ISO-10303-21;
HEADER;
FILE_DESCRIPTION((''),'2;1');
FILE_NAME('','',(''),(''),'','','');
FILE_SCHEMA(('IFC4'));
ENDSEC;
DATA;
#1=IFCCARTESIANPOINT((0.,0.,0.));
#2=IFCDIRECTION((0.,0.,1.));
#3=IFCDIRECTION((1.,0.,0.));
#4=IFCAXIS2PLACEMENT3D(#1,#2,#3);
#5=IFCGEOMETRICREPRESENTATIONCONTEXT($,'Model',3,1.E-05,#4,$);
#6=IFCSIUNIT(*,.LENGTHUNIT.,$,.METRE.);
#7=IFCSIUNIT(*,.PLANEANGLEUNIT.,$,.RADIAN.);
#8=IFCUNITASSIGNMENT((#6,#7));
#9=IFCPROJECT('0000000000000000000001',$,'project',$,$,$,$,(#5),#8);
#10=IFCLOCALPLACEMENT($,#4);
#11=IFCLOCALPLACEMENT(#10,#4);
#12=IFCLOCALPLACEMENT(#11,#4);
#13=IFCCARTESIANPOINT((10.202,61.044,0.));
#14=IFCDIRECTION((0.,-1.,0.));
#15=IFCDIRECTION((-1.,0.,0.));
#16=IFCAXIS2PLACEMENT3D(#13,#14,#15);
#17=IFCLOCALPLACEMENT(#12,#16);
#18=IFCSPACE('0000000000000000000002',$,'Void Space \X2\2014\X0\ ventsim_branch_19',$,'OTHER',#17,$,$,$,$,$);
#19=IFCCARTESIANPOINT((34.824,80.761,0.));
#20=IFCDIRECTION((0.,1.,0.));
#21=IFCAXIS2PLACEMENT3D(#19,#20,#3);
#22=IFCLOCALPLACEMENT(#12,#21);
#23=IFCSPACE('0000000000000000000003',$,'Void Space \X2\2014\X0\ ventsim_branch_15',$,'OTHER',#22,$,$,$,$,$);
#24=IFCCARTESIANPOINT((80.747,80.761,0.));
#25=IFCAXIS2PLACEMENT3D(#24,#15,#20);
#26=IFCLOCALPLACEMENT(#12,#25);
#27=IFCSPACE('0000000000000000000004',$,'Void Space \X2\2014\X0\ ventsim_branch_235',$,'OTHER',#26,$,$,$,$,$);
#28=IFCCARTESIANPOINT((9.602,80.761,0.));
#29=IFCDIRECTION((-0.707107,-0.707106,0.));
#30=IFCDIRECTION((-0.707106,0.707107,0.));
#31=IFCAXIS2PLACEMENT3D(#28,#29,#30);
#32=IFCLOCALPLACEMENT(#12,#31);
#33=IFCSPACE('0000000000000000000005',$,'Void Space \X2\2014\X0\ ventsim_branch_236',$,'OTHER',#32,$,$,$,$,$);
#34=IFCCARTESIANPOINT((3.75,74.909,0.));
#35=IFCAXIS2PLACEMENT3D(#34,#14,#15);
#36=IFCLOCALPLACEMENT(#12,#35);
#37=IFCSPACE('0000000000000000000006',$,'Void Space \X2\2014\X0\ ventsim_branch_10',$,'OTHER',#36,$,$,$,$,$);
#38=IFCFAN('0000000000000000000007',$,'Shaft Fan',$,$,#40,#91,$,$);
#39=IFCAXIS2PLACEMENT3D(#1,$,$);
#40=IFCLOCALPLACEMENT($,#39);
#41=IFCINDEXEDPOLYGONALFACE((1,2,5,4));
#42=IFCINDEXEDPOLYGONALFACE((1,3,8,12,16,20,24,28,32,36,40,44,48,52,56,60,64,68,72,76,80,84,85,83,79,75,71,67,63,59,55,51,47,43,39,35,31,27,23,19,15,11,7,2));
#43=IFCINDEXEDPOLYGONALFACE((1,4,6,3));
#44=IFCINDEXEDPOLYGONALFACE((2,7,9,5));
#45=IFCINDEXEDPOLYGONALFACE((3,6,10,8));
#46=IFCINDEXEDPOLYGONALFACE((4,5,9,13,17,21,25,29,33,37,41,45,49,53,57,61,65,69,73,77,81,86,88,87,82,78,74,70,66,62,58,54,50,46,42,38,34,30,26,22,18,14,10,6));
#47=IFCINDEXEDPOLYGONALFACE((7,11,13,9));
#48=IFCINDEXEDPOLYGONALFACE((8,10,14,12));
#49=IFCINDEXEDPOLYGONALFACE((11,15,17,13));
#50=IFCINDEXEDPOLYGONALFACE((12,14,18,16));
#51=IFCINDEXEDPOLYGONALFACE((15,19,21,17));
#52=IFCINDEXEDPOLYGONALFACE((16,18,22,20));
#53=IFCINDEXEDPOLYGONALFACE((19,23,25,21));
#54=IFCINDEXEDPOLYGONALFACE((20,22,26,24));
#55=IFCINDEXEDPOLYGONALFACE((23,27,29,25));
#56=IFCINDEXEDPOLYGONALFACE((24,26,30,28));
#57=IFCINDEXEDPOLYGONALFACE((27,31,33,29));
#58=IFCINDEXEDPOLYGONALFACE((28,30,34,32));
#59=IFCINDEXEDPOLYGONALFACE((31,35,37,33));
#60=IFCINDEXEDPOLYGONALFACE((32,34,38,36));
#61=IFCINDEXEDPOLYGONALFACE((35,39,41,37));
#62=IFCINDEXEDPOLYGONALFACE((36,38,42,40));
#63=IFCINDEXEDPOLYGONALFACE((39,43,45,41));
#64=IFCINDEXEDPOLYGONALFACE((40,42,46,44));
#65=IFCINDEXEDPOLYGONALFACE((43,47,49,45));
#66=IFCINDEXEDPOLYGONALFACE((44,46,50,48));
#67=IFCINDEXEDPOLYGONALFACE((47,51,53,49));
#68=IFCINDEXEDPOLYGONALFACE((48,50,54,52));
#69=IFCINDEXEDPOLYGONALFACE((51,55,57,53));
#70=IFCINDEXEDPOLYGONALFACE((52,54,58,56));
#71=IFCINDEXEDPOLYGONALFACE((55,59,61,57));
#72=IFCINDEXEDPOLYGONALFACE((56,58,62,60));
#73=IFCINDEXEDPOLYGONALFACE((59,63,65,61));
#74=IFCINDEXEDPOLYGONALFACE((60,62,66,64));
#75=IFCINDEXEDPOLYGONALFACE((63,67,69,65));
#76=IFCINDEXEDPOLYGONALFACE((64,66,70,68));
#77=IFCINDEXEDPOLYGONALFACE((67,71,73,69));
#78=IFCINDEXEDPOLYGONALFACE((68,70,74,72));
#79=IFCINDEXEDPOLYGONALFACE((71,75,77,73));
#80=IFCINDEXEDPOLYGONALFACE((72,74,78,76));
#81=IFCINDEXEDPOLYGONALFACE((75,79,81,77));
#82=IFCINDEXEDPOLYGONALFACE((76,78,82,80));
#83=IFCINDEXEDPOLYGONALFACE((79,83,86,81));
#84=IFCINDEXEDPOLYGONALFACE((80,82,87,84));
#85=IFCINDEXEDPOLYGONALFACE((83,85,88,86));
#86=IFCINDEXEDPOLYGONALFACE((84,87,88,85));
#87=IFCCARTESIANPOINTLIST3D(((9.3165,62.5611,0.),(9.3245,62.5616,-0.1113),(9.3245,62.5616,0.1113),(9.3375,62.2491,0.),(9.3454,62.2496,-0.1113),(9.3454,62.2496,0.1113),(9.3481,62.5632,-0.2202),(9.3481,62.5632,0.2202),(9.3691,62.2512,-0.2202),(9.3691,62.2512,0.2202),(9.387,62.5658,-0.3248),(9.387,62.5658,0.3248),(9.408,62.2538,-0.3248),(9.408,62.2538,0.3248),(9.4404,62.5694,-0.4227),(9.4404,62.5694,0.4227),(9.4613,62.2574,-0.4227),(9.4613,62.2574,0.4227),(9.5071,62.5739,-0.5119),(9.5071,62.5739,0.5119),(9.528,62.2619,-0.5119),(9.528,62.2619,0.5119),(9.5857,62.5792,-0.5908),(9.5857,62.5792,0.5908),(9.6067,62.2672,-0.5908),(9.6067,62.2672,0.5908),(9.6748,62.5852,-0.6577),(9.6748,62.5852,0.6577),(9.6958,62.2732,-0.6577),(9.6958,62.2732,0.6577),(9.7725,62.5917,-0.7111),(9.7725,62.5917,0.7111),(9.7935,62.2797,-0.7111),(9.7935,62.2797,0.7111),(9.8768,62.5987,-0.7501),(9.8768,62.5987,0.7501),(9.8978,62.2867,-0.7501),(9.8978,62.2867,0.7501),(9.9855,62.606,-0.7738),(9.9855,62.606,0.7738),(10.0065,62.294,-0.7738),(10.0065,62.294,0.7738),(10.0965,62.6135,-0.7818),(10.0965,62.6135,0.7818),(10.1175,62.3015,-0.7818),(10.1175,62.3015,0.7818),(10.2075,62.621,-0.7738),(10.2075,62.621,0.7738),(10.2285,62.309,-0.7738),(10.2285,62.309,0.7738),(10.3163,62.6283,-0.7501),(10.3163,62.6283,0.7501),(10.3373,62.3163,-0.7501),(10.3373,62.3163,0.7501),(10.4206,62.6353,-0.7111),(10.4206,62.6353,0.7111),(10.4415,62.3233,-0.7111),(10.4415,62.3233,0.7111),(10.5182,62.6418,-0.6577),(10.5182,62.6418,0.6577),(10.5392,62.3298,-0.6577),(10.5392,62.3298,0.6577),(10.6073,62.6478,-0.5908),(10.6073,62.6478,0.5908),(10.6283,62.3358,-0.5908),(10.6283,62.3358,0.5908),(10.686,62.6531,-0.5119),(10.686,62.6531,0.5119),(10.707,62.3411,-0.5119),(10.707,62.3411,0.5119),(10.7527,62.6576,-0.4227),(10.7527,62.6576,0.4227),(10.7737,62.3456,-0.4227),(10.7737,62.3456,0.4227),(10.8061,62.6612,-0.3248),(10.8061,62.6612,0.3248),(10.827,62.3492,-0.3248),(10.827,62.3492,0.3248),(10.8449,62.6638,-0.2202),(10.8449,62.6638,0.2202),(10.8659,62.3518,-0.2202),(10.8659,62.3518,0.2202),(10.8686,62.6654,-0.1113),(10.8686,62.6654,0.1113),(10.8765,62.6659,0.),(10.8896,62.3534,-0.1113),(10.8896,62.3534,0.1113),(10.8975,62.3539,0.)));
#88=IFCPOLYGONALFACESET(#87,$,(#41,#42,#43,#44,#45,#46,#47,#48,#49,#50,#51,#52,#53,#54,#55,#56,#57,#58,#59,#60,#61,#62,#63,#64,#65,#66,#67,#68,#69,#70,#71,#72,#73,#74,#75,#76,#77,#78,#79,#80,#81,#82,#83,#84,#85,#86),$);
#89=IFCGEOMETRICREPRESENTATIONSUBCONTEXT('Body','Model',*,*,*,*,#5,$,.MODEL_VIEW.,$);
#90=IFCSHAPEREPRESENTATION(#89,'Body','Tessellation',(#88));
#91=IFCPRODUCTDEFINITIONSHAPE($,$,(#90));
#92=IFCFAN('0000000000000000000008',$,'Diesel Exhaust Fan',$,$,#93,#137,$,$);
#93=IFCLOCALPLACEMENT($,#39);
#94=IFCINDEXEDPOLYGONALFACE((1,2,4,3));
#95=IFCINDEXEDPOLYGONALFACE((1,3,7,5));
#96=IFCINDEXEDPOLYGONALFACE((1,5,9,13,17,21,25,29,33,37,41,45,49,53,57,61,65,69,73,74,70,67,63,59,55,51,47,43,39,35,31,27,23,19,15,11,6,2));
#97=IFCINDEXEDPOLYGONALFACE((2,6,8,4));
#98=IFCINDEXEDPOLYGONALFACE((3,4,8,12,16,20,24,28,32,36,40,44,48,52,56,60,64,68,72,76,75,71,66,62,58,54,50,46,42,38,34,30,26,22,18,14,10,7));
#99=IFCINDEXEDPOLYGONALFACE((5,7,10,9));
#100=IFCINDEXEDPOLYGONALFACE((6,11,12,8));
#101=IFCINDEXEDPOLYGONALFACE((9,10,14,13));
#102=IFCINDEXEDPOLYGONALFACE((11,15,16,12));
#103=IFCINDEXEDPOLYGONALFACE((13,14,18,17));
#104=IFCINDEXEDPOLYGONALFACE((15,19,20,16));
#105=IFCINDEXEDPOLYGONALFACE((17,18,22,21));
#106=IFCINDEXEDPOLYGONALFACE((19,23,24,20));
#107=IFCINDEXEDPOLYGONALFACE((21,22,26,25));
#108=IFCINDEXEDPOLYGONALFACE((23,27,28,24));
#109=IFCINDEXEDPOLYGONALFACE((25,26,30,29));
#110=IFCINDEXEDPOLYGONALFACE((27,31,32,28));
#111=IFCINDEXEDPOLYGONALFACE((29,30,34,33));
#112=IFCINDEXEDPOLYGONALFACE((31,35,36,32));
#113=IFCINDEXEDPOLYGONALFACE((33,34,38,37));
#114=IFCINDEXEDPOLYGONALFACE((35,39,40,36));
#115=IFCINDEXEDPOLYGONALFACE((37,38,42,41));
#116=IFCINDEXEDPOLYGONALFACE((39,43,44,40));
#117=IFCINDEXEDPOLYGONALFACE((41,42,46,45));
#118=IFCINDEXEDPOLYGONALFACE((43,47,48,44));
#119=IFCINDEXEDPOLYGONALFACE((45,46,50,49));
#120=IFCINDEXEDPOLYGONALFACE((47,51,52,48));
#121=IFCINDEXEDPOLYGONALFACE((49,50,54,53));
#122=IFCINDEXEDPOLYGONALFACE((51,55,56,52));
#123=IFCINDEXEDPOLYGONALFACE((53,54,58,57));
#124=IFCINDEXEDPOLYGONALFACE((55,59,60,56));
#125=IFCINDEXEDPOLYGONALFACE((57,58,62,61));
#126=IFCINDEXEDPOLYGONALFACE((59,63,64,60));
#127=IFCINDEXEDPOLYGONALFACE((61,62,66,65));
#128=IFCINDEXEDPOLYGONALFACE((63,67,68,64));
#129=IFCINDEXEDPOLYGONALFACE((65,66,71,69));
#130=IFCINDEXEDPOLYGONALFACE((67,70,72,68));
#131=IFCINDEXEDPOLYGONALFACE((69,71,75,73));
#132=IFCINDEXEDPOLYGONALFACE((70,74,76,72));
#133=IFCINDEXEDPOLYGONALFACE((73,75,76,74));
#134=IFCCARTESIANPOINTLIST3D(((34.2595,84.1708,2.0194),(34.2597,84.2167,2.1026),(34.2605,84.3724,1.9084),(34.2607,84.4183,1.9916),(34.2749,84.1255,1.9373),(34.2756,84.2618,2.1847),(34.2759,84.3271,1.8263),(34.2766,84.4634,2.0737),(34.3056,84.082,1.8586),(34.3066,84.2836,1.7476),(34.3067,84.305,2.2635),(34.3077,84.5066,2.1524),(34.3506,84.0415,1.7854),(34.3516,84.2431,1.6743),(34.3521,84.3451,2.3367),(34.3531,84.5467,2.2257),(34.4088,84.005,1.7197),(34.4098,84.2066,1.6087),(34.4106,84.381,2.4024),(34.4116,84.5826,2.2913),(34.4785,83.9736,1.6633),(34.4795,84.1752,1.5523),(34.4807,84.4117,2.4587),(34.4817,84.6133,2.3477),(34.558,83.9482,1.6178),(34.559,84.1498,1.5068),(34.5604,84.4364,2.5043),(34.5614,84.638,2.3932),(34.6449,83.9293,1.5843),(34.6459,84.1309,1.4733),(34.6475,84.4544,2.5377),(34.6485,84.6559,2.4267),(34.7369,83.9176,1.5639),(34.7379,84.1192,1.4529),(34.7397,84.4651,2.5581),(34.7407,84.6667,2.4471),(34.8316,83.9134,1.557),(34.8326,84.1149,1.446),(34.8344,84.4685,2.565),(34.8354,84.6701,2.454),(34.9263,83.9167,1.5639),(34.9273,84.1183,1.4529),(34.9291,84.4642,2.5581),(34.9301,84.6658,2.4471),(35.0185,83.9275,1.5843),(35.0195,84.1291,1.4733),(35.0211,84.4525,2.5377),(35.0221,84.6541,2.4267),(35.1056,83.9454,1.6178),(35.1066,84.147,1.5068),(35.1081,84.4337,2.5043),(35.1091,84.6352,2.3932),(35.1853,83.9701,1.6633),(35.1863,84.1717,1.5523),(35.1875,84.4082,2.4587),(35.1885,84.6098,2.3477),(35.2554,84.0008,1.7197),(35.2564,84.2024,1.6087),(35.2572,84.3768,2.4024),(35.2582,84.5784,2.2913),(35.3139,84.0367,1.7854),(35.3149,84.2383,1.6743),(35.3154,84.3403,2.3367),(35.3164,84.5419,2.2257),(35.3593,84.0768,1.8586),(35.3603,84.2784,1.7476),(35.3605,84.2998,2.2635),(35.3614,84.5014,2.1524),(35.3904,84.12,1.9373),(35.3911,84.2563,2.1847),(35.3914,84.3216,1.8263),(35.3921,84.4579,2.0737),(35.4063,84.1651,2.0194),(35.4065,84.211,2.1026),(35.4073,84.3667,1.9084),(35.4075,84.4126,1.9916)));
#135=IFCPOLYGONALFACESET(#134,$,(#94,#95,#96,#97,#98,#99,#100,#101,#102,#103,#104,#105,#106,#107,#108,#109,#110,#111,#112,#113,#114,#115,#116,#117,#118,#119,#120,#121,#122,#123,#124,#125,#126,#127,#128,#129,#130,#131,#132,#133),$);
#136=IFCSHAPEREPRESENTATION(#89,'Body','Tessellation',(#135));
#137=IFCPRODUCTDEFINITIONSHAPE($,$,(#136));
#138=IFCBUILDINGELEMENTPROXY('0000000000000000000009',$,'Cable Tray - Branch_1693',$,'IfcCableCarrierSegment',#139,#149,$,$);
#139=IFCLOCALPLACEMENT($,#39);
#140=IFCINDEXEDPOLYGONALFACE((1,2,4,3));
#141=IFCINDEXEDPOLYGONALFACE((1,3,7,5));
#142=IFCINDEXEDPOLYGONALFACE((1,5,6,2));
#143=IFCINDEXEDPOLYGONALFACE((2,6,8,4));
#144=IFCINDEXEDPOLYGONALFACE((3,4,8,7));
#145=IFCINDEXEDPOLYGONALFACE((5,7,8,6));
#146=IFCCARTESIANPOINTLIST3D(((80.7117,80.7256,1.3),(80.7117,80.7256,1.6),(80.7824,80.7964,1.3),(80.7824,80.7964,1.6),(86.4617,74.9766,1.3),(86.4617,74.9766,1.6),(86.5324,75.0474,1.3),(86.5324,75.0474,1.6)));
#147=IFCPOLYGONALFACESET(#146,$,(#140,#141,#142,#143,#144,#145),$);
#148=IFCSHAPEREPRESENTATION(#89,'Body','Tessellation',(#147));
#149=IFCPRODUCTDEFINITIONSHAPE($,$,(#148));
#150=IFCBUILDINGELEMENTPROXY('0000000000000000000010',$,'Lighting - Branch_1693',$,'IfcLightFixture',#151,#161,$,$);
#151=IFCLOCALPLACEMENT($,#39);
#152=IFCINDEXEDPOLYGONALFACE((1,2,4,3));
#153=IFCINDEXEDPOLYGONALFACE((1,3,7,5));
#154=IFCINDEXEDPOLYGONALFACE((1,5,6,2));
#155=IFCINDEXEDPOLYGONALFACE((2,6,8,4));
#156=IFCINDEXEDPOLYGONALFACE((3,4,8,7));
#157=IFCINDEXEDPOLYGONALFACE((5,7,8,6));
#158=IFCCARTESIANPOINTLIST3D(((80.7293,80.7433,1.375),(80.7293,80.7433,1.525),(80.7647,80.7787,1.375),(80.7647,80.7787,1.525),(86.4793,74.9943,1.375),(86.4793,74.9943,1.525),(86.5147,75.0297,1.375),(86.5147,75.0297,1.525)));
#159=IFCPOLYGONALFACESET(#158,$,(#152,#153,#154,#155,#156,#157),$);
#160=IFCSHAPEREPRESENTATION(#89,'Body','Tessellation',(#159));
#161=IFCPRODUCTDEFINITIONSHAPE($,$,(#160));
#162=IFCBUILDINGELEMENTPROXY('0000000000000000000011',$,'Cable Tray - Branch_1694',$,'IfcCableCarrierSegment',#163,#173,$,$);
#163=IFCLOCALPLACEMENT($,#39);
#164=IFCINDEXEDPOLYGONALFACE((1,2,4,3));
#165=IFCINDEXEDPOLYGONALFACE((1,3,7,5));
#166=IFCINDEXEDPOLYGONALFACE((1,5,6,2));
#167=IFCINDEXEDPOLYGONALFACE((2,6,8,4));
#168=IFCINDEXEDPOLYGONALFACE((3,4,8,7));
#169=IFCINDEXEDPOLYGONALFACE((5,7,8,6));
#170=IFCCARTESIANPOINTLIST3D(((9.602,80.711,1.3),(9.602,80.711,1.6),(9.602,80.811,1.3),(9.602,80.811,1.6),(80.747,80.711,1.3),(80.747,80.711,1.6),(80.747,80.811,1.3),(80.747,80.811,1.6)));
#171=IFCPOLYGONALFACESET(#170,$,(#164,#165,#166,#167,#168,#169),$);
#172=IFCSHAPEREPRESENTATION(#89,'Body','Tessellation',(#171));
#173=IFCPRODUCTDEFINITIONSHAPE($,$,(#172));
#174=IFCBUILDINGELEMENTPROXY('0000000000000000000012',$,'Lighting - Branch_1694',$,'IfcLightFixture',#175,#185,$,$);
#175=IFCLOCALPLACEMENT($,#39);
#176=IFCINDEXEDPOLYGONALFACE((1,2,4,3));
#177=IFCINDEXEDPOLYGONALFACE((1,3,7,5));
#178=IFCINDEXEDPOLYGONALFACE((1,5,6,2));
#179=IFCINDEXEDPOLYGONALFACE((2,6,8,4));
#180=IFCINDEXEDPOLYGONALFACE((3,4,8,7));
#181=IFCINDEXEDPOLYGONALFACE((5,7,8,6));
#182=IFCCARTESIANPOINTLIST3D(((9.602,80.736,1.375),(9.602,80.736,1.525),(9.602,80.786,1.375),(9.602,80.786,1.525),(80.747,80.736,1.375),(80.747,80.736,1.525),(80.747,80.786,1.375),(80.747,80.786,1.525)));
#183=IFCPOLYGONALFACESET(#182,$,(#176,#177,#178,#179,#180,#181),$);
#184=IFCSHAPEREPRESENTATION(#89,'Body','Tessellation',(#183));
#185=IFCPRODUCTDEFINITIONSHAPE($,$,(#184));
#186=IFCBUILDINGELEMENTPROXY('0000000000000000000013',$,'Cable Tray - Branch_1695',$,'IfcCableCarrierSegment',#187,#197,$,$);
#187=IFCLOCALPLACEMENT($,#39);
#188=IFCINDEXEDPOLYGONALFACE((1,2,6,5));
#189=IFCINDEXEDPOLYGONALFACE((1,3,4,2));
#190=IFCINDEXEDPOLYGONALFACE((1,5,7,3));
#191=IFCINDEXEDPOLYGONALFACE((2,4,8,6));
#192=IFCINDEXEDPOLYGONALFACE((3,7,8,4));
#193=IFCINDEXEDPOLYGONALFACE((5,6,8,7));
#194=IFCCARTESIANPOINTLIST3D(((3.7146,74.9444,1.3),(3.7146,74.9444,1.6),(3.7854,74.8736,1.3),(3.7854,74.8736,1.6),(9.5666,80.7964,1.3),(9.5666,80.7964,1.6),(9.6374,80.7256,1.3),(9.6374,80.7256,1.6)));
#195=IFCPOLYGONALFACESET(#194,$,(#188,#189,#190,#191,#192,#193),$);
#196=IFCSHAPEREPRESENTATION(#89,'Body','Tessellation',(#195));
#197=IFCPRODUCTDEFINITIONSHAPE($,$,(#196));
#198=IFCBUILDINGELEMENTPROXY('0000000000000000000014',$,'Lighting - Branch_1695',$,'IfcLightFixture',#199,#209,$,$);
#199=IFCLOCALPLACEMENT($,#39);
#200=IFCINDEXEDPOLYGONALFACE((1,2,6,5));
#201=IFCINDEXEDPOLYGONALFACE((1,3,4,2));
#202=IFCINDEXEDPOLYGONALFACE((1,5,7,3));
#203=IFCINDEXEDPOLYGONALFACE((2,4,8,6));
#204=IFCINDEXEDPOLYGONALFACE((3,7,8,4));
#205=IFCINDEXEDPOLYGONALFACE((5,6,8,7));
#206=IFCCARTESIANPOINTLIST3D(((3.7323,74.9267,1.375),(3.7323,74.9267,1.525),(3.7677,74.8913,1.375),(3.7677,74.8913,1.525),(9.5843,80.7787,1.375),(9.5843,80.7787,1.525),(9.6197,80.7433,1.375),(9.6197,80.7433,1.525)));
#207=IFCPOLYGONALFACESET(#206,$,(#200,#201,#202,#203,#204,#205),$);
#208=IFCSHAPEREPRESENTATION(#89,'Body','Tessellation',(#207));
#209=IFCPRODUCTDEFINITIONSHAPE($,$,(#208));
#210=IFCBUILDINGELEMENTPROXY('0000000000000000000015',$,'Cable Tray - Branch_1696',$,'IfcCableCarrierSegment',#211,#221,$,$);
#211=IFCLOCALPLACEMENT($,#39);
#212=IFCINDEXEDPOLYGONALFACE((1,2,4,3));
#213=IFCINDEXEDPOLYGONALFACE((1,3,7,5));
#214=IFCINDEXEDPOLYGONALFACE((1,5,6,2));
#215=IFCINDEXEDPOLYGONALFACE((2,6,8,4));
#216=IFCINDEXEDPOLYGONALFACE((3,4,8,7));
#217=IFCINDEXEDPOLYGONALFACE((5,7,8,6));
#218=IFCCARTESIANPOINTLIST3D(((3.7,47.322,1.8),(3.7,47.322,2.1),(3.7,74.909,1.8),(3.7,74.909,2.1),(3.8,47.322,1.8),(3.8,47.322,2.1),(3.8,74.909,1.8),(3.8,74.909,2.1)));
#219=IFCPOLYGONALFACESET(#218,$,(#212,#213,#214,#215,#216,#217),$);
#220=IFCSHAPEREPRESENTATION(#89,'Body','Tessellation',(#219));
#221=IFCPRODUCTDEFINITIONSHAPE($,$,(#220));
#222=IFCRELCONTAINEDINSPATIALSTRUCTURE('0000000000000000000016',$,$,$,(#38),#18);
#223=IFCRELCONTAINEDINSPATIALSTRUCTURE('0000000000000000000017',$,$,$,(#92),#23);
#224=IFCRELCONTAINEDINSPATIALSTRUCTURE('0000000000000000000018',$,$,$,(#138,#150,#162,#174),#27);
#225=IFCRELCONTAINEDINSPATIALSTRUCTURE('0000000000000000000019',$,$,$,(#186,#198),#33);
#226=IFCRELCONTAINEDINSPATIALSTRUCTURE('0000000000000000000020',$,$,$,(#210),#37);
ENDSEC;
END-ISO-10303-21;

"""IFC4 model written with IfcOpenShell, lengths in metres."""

from ifc_helpers import new_model, si_unit, frame, origin_with_axes, origin_2d_with_axis, place, context, subcontext, project, spatial, rectangle, circle, extrude, element, save


model = new_model("IFC4")

# Units and contexts
model_context = context("Model", 3, precision=1e-05, world=origin_with_axes())
body_context = subcontext(model_context, "Body", "Model", "MODEL_VIEW")
ifc_project = project(units=[si_unit("LENGTHUNIT", "METRE"), si_unit("PLANEANGLEUNIT", "RADIAN")], contexts=[model_context])

# Space
placement_1 = place(None, origin_with_axes())
placement_2 = place(placement_1, origin_with_axes())
placement_3 = place(placement_2, origin_with_axes())
space_1_placement = place(placement_3, frame((10.202, 61.044, 0.0), z_axis=(0.0, -1.0, 0.0), x_axis=(-1.0, 0.0, 0.0)))
space_1 = spatial("IfcSpace", at=space_1_placement, Name="Void Space — ventsim_branch_19", ObjectType="OTHER")

# Fan
fan_1_placement = place(placement_3, frame((10.1175, 62.3015, 0.0), z_axis=(-0.067045, 0.99775, 0.0), x_axis=(0.0, 0.0, 1.0)))
element("IfcFan", 1, at=fan_1_placement, inside=space_1, Name="Shaft Fan", context=body_context, shape_type="SweptSolid", body=[
    extrude(circle(Radius=0.7818, at=origin_2d_with_axis()), origin_with_axes(), (0.0, 0.0, 1.0), 0.3127),
])

# Shared definitions
space_2_placement = place(placement_3, frame((34.824, 80.761, 0.0), z_axis=(0.0, 1.0, 0.0), x_axis=(1.0, 0.0, 0.0)))
space_2 = spatial("IfcSpace", at=space_2_placement, Name="Void Space — ventsim_branch_15", ObjectType="OTHER")

# Fan
fan_2_placement = place(placement_3, frame((34.834, 84.3925, 1.95), z_axis=(-0.004342, -0.875935, 0.482409), x_axis=(0.002391, 0.482404, 0.875946)))
element("IfcFan", 2, at=fan_2_placement, inside=space_2, Name="Diesel Exhaust Fan", context=body_context, shape_type="SweptSolid", body=[
    extrude(circle(Radius=0.5754, at=origin_2d_with_axis()), origin_with_axes(), (0.0, 0.0, 1.0), 0.2301),
])

# Shared definitions
space_3_placement = place(placement_3, frame((80.747, 80.761, 0.0), z_axis=(-1.0, 0.0, 0.0), x_axis=(0.0, 1.0, 0.0)))
space_3 = spatial("IfcSpace", at=space_3_placement, Name="Void Space — ventsim_branch_235", ObjectType="OTHER")

# Building element proxies
proxy_1_placement = place(placement_3, frame((80.747, 80.761, 1.45), z_axis=(0.707168, -0.707045, 0.0), x_axis=(0.0, 0.0, 1.0)))
element("IfcBuildingElementProxy", 3, at=proxy_1_placement, inside=space_3, Name="Cable Tray - Branch_1693", ObjectType="IfcCableCarrierSegment", context=body_context, shape_type="SweptSolid", body=[
    extrude(rectangle(XDim=0.3, YDim=0.1, at=origin_2d_with_axis()), origin_with_axes(), (0.0, 0.0, 1.0), 8.131),
])
proxy_2_placement = place(placement_3, frame((80.747, 80.761, 1.45), z_axis=(0.707168, -0.707045, 0.0), x_axis=(0.0, 0.0, 1.0)))
element("IfcBuildingElementProxy", 4, at=proxy_2_placement, inside=space_3, Name="Lighting - Branch_1693", ObjectType="IfcLightFixture", context=body_context, shape_type="SweptSolid", body=[
    extrude(rectangle(XDim=0.15, YDim=0.05, at=origin_2d_with_axis()), origin_with_axes(), (0.0, 0.0, 1.0), 8.131),
])
proxy_3_placement = place(placement_3, frame((80.747, 80.761, 1.45), z_axis=(-1.0, 0.0, 0.0), x_axis=(0.0, 0.0, 1.0)))
element("IfcBuildingElementProxy", 5, at=proxy_3_placement, inside=space_3, Name="Cable Tray - Branch_1694", ObjectType="IfcCableCarrierSegment", context=body_context, shape_type="SweptSolid", body=[
    extrude(rectangle(XDim=0.3, YDim=0.1, at=origin_2d_with_axis()), origin_with_axes(), (0.0, 0.0, 1.0), 71.145),
])
proxy_4_placement = place(placement_3, frame((80.747, 80.761, 1.45), z_axis=(-1.0, 0.0, 0.0), x_axis=(0.0, 0.0, 1.0)))
element("IfcBuildingElementProxy", 6, at=proxy_4_placement, inside=space_3, Name="Lighting - Branch_1694", ObjectType="IfcLightFixture", context=body_context, shape_type="SweptSolid", body=[
    extrude(rectangle(XDim=0.15, YDim=0.05, at=origin_2d_with_axis()), origin_with_axes(), (0.0, 0.0, 1.0), 71.145),
])

# Shared definitions
space_4_placement = place(placement_3, frame((9.602, 80.761, 0.0), z_axis=(-0.707107, -0.707106, 0.0), x_axis=(-0.707106, 0.707107, 0.0)))
space_4 = spatial("IfcSpace", at=space_4_placement, Name="Void Space — ventsim_branch_236", ObjectType="OTHER")

# Building element proxies
proxy_5_placement = place(placement_3, frame((9.602, 80.761, 1.45), z_axis=(-0.707107, -0.707106, 0.0), x_axis=(0.0, 0.0, 1.0)))
element("IfcBuildingElementProxy", 7, at=proxy_5_placement, inside=space_4, Name="Cable Tray - Branch_1695", ObjectType="IfcCableCarrierSegment", context=body_context, shape_type="SweptSolid", body=[
    extrude(rectangle(XDim=0.3, YDim=0.1, at=origin_2d_with_axis()), origin_with_axes(), (0.0, 0.0, 1.0), 8.276),
])
proxy_6_placement = place(placement_3, frame((9.602, 80.761, 1.45), z_axis=(-0.707107, -0.707106, 0.0), x_axis=(0.0, 0.0, 1.0)))
element("IfcBuildingElementProxy", 8, at=proxy_6_placement, inside=space_4, Name="Lighting - Branch_1695", ObjectType="IfcLightFixture", context=body_context, shape_type="SweptSolid", body=[
    extrude(rectangle(XDim=0.15, YDim=0.05, at=origin_2d_with_axis()), origin_with_axes(), (0.0, 0.0, 1.0), 8.276),
])

# Shared definitions
space_5_placement = place(placement_3, frame((3.75, 74.909, 0.0), z_axis=(0.0, -1.0, 0.0), x_axis=(-1.0, 0.0, 0.0)))
space_5 = spatial("IfcSpace", at=space_5_placement, Name="Void Space — ventsim_branch_10", ObjectType="OTHER")

# Building element proxy
proxy_7_placement = place(placement_3, frame((3.75, 74.909, 1.95), z_axis=(0.0, -1.0, 0.0), x_axis=(0.0, 0.0, 1.0)))
element("IfcBuildingElementProxy", 9, at=proxy_7_placement, inside=space_5, Name="Cable Tray - Branch_1696", ObjectType="IfcCableCarrierSegment", context=body_context, shape_type="SweptSolid", body=[
    extrude(rectangle(XDim=0.3, YDim=0.1, at=origin_2d_with_axis()), origin_with_axes(), (0.0, 0.0, 1.0), 27.587),
])

save(model, "model.ifc")
